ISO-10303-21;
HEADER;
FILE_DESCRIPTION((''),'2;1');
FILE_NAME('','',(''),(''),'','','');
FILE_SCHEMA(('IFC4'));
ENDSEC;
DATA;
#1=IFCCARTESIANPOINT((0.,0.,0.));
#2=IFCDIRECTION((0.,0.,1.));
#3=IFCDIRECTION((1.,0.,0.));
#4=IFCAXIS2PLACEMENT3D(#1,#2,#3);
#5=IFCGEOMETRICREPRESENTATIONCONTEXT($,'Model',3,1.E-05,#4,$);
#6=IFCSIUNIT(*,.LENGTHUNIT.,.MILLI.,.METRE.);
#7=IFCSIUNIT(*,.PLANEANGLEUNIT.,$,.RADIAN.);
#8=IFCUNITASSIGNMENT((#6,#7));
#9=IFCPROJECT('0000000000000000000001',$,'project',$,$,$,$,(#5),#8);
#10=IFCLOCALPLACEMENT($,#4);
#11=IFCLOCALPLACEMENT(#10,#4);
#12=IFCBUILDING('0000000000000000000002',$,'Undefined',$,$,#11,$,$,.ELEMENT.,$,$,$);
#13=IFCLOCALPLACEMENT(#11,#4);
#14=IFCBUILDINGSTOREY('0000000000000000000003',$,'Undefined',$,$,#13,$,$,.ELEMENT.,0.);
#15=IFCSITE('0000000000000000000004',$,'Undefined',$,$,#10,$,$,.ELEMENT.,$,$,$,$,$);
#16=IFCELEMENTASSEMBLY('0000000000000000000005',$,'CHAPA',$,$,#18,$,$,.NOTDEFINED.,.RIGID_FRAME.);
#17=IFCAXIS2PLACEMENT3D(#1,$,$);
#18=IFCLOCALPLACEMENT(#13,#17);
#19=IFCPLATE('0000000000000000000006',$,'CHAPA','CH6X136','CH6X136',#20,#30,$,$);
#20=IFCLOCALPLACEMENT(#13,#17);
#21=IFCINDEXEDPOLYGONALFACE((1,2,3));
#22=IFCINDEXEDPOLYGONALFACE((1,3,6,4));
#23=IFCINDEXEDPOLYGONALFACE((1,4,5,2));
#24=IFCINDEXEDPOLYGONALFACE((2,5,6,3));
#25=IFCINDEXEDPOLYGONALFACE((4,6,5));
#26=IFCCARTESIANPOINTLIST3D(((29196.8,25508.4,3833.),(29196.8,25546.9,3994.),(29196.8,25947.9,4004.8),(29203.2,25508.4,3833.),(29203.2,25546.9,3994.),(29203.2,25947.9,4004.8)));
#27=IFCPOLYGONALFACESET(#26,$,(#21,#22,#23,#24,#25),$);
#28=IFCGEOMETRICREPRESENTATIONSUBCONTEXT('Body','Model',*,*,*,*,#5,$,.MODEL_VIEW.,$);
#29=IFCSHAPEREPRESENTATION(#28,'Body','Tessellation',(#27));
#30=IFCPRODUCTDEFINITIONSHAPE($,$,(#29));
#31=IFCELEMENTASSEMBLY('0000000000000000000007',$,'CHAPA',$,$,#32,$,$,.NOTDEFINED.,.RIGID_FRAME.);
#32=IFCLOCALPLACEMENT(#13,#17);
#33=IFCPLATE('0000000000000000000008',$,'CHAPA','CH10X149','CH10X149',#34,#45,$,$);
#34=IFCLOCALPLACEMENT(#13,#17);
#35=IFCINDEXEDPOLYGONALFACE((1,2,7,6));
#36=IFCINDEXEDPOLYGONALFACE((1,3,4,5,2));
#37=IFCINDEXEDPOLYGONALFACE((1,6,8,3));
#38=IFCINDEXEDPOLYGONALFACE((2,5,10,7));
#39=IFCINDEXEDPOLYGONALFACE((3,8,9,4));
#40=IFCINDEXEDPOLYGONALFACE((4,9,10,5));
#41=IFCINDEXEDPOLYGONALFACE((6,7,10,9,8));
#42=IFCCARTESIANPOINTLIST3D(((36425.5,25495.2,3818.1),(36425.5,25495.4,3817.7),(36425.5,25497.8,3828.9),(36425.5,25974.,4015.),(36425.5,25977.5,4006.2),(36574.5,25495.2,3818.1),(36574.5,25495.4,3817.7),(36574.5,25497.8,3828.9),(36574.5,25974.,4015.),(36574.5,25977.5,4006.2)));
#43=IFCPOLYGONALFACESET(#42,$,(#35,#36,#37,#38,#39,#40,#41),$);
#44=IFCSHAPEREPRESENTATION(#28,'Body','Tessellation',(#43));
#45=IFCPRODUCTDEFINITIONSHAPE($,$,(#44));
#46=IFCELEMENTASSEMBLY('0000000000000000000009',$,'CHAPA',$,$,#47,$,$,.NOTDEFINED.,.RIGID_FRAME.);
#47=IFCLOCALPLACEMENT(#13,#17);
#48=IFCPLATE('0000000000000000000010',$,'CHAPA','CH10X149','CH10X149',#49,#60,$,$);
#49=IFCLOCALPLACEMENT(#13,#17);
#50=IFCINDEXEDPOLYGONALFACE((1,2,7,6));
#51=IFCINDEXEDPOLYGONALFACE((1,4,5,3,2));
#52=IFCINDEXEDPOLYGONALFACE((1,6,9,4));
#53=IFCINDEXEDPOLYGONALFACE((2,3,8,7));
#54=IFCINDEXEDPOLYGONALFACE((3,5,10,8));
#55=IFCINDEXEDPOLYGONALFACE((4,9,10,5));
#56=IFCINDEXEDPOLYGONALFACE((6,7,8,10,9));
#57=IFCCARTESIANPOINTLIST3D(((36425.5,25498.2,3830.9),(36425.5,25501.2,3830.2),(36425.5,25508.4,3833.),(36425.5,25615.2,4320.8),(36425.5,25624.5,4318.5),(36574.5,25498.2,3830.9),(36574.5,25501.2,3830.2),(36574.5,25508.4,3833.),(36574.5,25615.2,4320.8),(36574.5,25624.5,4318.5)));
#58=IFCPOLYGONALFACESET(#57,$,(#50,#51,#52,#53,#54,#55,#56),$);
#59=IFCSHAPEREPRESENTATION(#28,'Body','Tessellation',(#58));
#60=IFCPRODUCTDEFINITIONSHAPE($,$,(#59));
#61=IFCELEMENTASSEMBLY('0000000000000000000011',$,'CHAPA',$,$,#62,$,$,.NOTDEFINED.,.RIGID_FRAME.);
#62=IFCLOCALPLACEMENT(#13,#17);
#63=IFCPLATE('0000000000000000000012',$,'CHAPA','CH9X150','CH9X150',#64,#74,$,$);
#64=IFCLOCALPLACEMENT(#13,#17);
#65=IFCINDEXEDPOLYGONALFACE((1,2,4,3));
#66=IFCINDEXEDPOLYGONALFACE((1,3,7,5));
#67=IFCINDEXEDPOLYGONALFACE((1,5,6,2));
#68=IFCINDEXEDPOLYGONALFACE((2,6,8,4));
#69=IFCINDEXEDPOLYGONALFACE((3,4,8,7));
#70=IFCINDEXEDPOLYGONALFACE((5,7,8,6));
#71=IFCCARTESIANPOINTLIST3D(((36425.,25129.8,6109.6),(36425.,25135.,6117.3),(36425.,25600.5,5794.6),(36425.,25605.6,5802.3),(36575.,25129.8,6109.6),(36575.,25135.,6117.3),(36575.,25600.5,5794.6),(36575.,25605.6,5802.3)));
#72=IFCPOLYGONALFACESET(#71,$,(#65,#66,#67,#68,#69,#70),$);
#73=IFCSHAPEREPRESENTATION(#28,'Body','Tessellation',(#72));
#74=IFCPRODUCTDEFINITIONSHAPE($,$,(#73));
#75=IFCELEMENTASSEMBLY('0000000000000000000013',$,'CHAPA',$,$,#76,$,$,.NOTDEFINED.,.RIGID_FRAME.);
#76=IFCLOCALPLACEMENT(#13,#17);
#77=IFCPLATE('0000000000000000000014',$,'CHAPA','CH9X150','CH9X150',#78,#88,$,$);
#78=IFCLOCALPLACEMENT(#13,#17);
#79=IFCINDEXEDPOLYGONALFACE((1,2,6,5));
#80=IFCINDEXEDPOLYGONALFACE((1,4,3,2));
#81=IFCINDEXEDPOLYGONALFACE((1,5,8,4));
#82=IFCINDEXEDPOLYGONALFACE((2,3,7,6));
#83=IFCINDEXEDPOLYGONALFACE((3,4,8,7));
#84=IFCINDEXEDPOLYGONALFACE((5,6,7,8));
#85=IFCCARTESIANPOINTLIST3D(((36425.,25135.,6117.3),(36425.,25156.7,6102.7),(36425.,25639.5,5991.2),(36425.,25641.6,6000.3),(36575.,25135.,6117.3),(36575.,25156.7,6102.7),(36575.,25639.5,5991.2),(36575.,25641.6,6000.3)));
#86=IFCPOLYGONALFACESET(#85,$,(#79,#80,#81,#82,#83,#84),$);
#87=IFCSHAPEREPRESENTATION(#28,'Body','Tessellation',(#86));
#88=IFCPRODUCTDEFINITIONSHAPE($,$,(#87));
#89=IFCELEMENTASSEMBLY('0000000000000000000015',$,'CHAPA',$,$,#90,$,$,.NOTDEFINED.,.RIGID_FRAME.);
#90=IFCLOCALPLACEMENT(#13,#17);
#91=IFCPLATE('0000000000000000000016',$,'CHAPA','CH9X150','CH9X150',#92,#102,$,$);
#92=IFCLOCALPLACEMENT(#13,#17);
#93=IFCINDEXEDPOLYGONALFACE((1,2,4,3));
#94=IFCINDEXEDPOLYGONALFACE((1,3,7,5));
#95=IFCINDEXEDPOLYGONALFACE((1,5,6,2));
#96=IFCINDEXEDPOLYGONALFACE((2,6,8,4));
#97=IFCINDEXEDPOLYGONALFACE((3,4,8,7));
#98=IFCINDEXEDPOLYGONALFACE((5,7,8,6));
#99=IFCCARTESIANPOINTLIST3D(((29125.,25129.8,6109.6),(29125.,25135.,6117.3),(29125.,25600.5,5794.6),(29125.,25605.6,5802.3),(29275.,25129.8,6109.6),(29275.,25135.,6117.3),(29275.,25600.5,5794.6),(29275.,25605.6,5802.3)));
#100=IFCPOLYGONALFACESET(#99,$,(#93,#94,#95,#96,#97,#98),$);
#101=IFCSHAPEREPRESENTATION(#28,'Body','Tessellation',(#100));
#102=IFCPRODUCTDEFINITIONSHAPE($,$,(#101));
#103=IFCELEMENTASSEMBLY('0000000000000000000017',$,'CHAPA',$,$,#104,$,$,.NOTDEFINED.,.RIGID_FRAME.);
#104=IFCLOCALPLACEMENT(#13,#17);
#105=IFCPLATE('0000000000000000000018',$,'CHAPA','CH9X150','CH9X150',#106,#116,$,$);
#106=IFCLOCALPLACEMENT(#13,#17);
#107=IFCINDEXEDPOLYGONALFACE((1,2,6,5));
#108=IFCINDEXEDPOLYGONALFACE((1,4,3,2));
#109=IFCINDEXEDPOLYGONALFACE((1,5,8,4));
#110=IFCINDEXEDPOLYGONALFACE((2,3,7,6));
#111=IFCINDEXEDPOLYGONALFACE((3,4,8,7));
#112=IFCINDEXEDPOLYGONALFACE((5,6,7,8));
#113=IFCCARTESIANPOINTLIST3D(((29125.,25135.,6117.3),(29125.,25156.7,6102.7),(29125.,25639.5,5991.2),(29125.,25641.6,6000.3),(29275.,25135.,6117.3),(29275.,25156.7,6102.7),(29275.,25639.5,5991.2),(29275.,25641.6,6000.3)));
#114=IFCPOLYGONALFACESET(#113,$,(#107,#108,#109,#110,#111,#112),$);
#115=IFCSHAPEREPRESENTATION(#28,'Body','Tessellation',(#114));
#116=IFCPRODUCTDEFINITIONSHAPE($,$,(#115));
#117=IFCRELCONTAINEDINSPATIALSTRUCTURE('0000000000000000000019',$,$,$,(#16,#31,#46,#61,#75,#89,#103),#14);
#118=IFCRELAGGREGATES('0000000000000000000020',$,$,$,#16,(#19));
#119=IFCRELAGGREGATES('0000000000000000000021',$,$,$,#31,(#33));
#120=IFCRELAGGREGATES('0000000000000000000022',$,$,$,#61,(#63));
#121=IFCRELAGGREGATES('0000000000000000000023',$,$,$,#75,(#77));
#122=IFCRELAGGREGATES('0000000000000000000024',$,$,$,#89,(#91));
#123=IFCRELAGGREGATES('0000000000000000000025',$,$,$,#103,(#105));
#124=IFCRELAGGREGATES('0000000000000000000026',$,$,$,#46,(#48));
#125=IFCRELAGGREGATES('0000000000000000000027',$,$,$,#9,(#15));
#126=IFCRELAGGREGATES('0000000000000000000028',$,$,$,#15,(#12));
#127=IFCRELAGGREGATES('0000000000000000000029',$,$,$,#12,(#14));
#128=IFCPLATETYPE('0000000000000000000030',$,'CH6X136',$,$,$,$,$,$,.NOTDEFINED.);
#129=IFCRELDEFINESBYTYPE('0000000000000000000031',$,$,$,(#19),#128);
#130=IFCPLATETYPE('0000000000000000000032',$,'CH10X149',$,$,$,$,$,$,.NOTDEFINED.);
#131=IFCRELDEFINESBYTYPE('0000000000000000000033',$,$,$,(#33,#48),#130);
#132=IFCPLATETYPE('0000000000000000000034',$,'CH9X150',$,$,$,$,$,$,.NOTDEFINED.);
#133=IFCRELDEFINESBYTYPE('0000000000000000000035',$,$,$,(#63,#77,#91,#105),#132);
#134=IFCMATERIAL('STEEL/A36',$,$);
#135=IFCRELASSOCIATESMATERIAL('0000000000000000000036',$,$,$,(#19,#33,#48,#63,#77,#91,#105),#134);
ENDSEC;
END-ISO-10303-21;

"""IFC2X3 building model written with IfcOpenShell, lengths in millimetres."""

from ifc_helpers import new_model, si_unit, frame, origin_with_axes, place, context, subcontext, project, spatial, polyline, outline, extrude, clip, halfspace, material, type_object, element, aggregate, save


model = new_model("IFC2X3")

# Units and contexts
model_context = context("Model", 3, precision=1e-05, world=origin_with_axes())
body_context = subcontext(model_context, "Body", "Model", "MODEL_VIEW")
ifc_project = project(units=[si_unit("LENGTHUNIT", "METRE", prefix="MILLI"), si_unit("PLANEANGLEUNIT", "RADIAN")], contexts=[model_context])

# Site, building, storey
site_placement = place(None, origin_with_axes())
site = spatial("IfcSite", under=ifc_project, at=site_placement, Name="Undefined", CompositionType="ELEMENT")
building_placement = place(site_placement, origin_with_axes())
building = spatial("IfcBuilding", under=site, at=building_placement, Name="Undefined", CompositionType="ELEMENT")
storey_placement = place(building_placement, origin_with_axes())
storey = spatial("IfcBuildingStorey", under=building, at=storey_placement, Name="Undefined", CompositionType="ELEMENT", Elevation=0.0)

# Shared definitions
ifc_material_1 = material(Name="STEEL/A36")

# Element assemblies, plates
plate_type_1 = type_object("IfcPlateType", Name="CH6X136", PredefinedType="NOTDEFINED")
assembly_1_placement = place(storey_placement, origin_with_axes())
assembly_1 = element("IfcElementAssembly", 1, at=assembly_1_placement, inside=storey, Name="CHAPA", AssemblyPlace="NOTDEFINED", PredefinedType="RIGID_FRAME")
plate_1_placement = place(assembly_1_placement, frame((29200.0, 25546.9, 3994.0), z_axis=(-1.0, 0.0, 0.0), x_axis=(0.0, 0.999636, 0.026972)))
plate_1 = element("IfcPlate", 2, at=plate_1_placement, type_object=plate_type_1, material=ifc_material_1, Name="CHAPA", Description="CH6X136", ObjectType="CH6X136", context=body_context, shape_type="SweptSolid", body=[
    extrude(outline(polyline([(0.0, 0.0), (401.1, 0.0), (-42.8, 159.9), (0.0, 0.0)])), frame((0.0, 0.0, -3.1), z_axis=(0.0, 0.0, 1.0), x_axis=(1.0, 0.0, 0.0)), (0.0, 0.0, 1.0), 6.3),
])
aggregate(assembly_1, [plate_1])
assembly_2_placement = place(storey_placement, origin_with_axes())
assembly_2 = element("IfcElementAssembly", 3, at=assembly_2_placement, inside=storey, Name="CHAPA", AssemblyPlace="NOTDEFINED", PredefinedType="RIGID_FRAME")
plate_type_2 = type_object("IfcPlateType", Name="CH10X149", PredefinedType="NOTDEFINED")
plate_2_placement = place(assembly_2_placement, frame((36425.5, 25975.7, 4010.6), z_axis=(0.0, 0.364063, -0.931374), x_axis=(1.0, 0.0, 0.0)))
plate_2 = element("IfcPlate", 4, at=plate_2_placement, type_object=plate_type_2, material=ifc_material_1, Name="CHAPA", Description="CH10X149", ObjectType="CH10X149", context=body_context, shape_type="Clipping", body=[
    clip(extrude(outline(polyline([(0.0, 0.0), (149.0, 0.0), (149.0, 517.6), (0.0, 517.6), (0.0, 0.0)])), frame((0.0, 0.0, -4.8), z_axis=(0.0, 0.0, 1.0), x_axis=(1.0, 0.0, 0.0)), (0.0, 0.0, 1.0), 9.5), halfspace(frame((149.0, 517.9, 4.7), z_axis=(0.0, 0.821204, -0.570634), x_axis=(-1.0, 0.0, 0.0)), False)),
])
aggregate(assembly_2, [plate_2])
assembly_3_placement = place(storey_placement, origin_with_axes())
assembly_3 = element("IfcElementAssembly", 5, at=assembly_3_placement, inside=storey, Name="CHAPA", AssemblyPlace="NOTDEFINED", PredefinedType="RIGID_FRAME")
plate_3_placement = place(assembly_3_placement, frame((36425.5, 25619.9, 4319.6), z_axis=(0.0, 0.972612, -0.232434), x_axis=(1.0, 0.000007, 0.000031)))
plate_3 = element("IfcPlate", 6, at=plate_3_placement, type_object=plate_type_2, material=ifc_material_1, Name="CHAPA", Description="CH10X149", ObjectType="CH10X149", context=body_context, shape_type="Clipping", body=[
    clip(extrude(outline(polyline([(0.0, 0.0), (70.9, 0.0), (149.0, 0.0), (149.0, 503.6), (0.0, 503.6), (0.0, 0.0)])), frame((0.0, 0.0, -4.8), z_axis=(0.0, 0.0, 1.0), x_axis=(1.0, 0.0, 0.0)), (0.0, 0.0, 1.0), 9.5), halfspace(frame((70.9, 499.2, 4.7), z_axis=(-0.000026, 0.821245, 0.570575), x_axis=(-1.0, -0.000032, 0.0)), False)),
])
assembly_4_placement = place(storey_placement, origin_with_axes())
assembly_4 = element("IfcElementAssembly", 7, at=assembly_4_placement, inside=storey, Name="CHAPA", AssemblyPlace="NOTDEFINED", PredefinedType="RIGID_FRAME")
plate_type_3 = type_object("IfcPlateType", Name="CH9X150", PredefinedType="NOTDEFINED")
plate_4_placement = place(assembly_4_placement, frame((36575.0, 25132.4, 6113.5), z_axis=(0.0, -0.55615, -0.831082), x_axis=(-1.0, 0.0, 0.0)))
plate_4 = element("IfcPlate", 8, at=plate_4_placement, type_object=plate_type_3, material=ifc_material_1, Name="CHAPA", Description="CH9X150", ObjectType="CH9X150", context=body_context, shape_type="SweptSolid", body=[
    extrude(outline(polyline([(0.0, 0.0), (150.0, 0.0), (150.0, 566.3), (0.0, 566.3), (0.0, 0.0)])), frame((0.0, 0.0, -4.7), z_axis=(0.0, 0.0, 1.0), x_axis=(1.0, 0.0, 0.0)), (0.0, 0.0, 1.0), 9.3),
])
aggregate(assembly_4, [plate_4])
assembly_5_placement = place(storey_placement, origin_with_axes())
assembly_5 = element("IfcElementAssembly", 9, at=assembly_5_placement, inside=storey, Name="CHAPA", AssemblyPlace="NOTDEFINED", PredefinedType="RIGID_FRAME")
plate_5_placement = place(assembly_5_placement, frame((36575.0, 25640.6, 5995.7), z_axis=(0.0, -0.225124, -0.97433), x_axis=(0.0, -0.97433, 0.225124)))
plate_5 = element("IfcPlate", 10, at=plate_5_placement, type_object=plate_type_3, material=ifc_material_1, Name="CHAPA", Description="CH9X150", ObjectType="CH9X150", context=body_context, shape_type="Clipping", body=[
    clip(extrude(outline(polyline([(0.0, 0.0), (520.0, 0.0), (520.0, 150.0), (0.0, 150.0), (0.0, 0.0)])), frame((0.0, 0.0, -4.7), z_axis=(0.0, 0.0, 1.0), x_axis=(1.0, 0.0, 0.0)), (0.0, 0.0, 1.0), 9.3), halfspace(frame((520.0, -500.0, -4.7), z_axis=(0.354778, 0.0, 0.934951), x_axis=(-0.934951, 0.0, 0.354778)), False)),
])
aggregate(assembly_5, [plate_5])
assembly_6_placement = place(storey_placement, origin_with_axes())
assembly_6 = element("IfcElementAssembly", 11, at=assembly_6_placement, inside=storey, Name="CHAPA", AssemblyPlace="NOTDEFINED", PredefinedType="RIGID_FRAME")
plate_6_placement = place(assembly_6_placement, frame((29275.0, 25132.4, 6113.5), z_axis=(0.0, -0.55615, -0.831082), x_axis=(-1.0, 0.0, 0.0)))
plate_6 = element("IfcPlate", 12, at=plate_6_placement, type_object=plate_type_3, material=ifc_material_1, Name="CHAPA", Description="CH9X150", ObjectType="CH9X150", context=body_context, shape_type="SweptSolid", body=[
    extrude(outline(polyline([(0.0, 0.0), (150.0, 0.0), (150.0, 566.3), (0.0, 566.3), (0.0, 0.0)])), frame((0.0, 0.0, -4.7), z_axis=(0.0, 0.0, 1.0), x_axis=(1.0, 0.0, 0.0)), (0.0, 0.0, 1.0), 9.3),
])
aggregate(assembly_6, [plate_6])
assembly_7_placement = place(storey_placement, origin_with_axes())
assembly_7 = element("IfcElementAssembly", 13, at=assembly_7_placement, inside=storey, Name="CHAPA", AssemblyPlace="NOTDEFINED", PredefinedType="RIGID_FRAME")
plate_7_placement = place(assembly_7_placement, frame((29275.0, 25640.6, 5995.7), z_axis=(0.0, -0.225124, -0.97433), x_axis=(0.0, -0.97433, 0.225124)))
plate_7 = element("IfcPlate", 14, at=plate_7_placement, type_object=plate_type_3, material=ifc_material_1, Name="CHAPA", Description="CH9X150", ObjectType="CH9X150", context=body_context, shape_type="Clipping", body=[
    clip(extrude(outline(polyline([(0.0, 0.0), (520.0, 0.0), (520.0, 150.0), (0.0, 150.0), (0.0, 0.0)])), frame((0.0, 0.0, -4.7), z_axis=(0.0, 0.0, 1.0), x_axis=(1.0, 0.0, 0.0)), (0.0, 0.0, 1.0), 9.3), halfspace(frame((520.0, -500.0, -4.7), z_axis=(0.354778, 0.0, 0.934951), x_axis=(-0.934951, 0.0, 0.354778)), False)),
])
aggregate(assembly_7, [plate_7])

aggregate(assembly_3, [plate_3])

save(model, "model.ifc")
